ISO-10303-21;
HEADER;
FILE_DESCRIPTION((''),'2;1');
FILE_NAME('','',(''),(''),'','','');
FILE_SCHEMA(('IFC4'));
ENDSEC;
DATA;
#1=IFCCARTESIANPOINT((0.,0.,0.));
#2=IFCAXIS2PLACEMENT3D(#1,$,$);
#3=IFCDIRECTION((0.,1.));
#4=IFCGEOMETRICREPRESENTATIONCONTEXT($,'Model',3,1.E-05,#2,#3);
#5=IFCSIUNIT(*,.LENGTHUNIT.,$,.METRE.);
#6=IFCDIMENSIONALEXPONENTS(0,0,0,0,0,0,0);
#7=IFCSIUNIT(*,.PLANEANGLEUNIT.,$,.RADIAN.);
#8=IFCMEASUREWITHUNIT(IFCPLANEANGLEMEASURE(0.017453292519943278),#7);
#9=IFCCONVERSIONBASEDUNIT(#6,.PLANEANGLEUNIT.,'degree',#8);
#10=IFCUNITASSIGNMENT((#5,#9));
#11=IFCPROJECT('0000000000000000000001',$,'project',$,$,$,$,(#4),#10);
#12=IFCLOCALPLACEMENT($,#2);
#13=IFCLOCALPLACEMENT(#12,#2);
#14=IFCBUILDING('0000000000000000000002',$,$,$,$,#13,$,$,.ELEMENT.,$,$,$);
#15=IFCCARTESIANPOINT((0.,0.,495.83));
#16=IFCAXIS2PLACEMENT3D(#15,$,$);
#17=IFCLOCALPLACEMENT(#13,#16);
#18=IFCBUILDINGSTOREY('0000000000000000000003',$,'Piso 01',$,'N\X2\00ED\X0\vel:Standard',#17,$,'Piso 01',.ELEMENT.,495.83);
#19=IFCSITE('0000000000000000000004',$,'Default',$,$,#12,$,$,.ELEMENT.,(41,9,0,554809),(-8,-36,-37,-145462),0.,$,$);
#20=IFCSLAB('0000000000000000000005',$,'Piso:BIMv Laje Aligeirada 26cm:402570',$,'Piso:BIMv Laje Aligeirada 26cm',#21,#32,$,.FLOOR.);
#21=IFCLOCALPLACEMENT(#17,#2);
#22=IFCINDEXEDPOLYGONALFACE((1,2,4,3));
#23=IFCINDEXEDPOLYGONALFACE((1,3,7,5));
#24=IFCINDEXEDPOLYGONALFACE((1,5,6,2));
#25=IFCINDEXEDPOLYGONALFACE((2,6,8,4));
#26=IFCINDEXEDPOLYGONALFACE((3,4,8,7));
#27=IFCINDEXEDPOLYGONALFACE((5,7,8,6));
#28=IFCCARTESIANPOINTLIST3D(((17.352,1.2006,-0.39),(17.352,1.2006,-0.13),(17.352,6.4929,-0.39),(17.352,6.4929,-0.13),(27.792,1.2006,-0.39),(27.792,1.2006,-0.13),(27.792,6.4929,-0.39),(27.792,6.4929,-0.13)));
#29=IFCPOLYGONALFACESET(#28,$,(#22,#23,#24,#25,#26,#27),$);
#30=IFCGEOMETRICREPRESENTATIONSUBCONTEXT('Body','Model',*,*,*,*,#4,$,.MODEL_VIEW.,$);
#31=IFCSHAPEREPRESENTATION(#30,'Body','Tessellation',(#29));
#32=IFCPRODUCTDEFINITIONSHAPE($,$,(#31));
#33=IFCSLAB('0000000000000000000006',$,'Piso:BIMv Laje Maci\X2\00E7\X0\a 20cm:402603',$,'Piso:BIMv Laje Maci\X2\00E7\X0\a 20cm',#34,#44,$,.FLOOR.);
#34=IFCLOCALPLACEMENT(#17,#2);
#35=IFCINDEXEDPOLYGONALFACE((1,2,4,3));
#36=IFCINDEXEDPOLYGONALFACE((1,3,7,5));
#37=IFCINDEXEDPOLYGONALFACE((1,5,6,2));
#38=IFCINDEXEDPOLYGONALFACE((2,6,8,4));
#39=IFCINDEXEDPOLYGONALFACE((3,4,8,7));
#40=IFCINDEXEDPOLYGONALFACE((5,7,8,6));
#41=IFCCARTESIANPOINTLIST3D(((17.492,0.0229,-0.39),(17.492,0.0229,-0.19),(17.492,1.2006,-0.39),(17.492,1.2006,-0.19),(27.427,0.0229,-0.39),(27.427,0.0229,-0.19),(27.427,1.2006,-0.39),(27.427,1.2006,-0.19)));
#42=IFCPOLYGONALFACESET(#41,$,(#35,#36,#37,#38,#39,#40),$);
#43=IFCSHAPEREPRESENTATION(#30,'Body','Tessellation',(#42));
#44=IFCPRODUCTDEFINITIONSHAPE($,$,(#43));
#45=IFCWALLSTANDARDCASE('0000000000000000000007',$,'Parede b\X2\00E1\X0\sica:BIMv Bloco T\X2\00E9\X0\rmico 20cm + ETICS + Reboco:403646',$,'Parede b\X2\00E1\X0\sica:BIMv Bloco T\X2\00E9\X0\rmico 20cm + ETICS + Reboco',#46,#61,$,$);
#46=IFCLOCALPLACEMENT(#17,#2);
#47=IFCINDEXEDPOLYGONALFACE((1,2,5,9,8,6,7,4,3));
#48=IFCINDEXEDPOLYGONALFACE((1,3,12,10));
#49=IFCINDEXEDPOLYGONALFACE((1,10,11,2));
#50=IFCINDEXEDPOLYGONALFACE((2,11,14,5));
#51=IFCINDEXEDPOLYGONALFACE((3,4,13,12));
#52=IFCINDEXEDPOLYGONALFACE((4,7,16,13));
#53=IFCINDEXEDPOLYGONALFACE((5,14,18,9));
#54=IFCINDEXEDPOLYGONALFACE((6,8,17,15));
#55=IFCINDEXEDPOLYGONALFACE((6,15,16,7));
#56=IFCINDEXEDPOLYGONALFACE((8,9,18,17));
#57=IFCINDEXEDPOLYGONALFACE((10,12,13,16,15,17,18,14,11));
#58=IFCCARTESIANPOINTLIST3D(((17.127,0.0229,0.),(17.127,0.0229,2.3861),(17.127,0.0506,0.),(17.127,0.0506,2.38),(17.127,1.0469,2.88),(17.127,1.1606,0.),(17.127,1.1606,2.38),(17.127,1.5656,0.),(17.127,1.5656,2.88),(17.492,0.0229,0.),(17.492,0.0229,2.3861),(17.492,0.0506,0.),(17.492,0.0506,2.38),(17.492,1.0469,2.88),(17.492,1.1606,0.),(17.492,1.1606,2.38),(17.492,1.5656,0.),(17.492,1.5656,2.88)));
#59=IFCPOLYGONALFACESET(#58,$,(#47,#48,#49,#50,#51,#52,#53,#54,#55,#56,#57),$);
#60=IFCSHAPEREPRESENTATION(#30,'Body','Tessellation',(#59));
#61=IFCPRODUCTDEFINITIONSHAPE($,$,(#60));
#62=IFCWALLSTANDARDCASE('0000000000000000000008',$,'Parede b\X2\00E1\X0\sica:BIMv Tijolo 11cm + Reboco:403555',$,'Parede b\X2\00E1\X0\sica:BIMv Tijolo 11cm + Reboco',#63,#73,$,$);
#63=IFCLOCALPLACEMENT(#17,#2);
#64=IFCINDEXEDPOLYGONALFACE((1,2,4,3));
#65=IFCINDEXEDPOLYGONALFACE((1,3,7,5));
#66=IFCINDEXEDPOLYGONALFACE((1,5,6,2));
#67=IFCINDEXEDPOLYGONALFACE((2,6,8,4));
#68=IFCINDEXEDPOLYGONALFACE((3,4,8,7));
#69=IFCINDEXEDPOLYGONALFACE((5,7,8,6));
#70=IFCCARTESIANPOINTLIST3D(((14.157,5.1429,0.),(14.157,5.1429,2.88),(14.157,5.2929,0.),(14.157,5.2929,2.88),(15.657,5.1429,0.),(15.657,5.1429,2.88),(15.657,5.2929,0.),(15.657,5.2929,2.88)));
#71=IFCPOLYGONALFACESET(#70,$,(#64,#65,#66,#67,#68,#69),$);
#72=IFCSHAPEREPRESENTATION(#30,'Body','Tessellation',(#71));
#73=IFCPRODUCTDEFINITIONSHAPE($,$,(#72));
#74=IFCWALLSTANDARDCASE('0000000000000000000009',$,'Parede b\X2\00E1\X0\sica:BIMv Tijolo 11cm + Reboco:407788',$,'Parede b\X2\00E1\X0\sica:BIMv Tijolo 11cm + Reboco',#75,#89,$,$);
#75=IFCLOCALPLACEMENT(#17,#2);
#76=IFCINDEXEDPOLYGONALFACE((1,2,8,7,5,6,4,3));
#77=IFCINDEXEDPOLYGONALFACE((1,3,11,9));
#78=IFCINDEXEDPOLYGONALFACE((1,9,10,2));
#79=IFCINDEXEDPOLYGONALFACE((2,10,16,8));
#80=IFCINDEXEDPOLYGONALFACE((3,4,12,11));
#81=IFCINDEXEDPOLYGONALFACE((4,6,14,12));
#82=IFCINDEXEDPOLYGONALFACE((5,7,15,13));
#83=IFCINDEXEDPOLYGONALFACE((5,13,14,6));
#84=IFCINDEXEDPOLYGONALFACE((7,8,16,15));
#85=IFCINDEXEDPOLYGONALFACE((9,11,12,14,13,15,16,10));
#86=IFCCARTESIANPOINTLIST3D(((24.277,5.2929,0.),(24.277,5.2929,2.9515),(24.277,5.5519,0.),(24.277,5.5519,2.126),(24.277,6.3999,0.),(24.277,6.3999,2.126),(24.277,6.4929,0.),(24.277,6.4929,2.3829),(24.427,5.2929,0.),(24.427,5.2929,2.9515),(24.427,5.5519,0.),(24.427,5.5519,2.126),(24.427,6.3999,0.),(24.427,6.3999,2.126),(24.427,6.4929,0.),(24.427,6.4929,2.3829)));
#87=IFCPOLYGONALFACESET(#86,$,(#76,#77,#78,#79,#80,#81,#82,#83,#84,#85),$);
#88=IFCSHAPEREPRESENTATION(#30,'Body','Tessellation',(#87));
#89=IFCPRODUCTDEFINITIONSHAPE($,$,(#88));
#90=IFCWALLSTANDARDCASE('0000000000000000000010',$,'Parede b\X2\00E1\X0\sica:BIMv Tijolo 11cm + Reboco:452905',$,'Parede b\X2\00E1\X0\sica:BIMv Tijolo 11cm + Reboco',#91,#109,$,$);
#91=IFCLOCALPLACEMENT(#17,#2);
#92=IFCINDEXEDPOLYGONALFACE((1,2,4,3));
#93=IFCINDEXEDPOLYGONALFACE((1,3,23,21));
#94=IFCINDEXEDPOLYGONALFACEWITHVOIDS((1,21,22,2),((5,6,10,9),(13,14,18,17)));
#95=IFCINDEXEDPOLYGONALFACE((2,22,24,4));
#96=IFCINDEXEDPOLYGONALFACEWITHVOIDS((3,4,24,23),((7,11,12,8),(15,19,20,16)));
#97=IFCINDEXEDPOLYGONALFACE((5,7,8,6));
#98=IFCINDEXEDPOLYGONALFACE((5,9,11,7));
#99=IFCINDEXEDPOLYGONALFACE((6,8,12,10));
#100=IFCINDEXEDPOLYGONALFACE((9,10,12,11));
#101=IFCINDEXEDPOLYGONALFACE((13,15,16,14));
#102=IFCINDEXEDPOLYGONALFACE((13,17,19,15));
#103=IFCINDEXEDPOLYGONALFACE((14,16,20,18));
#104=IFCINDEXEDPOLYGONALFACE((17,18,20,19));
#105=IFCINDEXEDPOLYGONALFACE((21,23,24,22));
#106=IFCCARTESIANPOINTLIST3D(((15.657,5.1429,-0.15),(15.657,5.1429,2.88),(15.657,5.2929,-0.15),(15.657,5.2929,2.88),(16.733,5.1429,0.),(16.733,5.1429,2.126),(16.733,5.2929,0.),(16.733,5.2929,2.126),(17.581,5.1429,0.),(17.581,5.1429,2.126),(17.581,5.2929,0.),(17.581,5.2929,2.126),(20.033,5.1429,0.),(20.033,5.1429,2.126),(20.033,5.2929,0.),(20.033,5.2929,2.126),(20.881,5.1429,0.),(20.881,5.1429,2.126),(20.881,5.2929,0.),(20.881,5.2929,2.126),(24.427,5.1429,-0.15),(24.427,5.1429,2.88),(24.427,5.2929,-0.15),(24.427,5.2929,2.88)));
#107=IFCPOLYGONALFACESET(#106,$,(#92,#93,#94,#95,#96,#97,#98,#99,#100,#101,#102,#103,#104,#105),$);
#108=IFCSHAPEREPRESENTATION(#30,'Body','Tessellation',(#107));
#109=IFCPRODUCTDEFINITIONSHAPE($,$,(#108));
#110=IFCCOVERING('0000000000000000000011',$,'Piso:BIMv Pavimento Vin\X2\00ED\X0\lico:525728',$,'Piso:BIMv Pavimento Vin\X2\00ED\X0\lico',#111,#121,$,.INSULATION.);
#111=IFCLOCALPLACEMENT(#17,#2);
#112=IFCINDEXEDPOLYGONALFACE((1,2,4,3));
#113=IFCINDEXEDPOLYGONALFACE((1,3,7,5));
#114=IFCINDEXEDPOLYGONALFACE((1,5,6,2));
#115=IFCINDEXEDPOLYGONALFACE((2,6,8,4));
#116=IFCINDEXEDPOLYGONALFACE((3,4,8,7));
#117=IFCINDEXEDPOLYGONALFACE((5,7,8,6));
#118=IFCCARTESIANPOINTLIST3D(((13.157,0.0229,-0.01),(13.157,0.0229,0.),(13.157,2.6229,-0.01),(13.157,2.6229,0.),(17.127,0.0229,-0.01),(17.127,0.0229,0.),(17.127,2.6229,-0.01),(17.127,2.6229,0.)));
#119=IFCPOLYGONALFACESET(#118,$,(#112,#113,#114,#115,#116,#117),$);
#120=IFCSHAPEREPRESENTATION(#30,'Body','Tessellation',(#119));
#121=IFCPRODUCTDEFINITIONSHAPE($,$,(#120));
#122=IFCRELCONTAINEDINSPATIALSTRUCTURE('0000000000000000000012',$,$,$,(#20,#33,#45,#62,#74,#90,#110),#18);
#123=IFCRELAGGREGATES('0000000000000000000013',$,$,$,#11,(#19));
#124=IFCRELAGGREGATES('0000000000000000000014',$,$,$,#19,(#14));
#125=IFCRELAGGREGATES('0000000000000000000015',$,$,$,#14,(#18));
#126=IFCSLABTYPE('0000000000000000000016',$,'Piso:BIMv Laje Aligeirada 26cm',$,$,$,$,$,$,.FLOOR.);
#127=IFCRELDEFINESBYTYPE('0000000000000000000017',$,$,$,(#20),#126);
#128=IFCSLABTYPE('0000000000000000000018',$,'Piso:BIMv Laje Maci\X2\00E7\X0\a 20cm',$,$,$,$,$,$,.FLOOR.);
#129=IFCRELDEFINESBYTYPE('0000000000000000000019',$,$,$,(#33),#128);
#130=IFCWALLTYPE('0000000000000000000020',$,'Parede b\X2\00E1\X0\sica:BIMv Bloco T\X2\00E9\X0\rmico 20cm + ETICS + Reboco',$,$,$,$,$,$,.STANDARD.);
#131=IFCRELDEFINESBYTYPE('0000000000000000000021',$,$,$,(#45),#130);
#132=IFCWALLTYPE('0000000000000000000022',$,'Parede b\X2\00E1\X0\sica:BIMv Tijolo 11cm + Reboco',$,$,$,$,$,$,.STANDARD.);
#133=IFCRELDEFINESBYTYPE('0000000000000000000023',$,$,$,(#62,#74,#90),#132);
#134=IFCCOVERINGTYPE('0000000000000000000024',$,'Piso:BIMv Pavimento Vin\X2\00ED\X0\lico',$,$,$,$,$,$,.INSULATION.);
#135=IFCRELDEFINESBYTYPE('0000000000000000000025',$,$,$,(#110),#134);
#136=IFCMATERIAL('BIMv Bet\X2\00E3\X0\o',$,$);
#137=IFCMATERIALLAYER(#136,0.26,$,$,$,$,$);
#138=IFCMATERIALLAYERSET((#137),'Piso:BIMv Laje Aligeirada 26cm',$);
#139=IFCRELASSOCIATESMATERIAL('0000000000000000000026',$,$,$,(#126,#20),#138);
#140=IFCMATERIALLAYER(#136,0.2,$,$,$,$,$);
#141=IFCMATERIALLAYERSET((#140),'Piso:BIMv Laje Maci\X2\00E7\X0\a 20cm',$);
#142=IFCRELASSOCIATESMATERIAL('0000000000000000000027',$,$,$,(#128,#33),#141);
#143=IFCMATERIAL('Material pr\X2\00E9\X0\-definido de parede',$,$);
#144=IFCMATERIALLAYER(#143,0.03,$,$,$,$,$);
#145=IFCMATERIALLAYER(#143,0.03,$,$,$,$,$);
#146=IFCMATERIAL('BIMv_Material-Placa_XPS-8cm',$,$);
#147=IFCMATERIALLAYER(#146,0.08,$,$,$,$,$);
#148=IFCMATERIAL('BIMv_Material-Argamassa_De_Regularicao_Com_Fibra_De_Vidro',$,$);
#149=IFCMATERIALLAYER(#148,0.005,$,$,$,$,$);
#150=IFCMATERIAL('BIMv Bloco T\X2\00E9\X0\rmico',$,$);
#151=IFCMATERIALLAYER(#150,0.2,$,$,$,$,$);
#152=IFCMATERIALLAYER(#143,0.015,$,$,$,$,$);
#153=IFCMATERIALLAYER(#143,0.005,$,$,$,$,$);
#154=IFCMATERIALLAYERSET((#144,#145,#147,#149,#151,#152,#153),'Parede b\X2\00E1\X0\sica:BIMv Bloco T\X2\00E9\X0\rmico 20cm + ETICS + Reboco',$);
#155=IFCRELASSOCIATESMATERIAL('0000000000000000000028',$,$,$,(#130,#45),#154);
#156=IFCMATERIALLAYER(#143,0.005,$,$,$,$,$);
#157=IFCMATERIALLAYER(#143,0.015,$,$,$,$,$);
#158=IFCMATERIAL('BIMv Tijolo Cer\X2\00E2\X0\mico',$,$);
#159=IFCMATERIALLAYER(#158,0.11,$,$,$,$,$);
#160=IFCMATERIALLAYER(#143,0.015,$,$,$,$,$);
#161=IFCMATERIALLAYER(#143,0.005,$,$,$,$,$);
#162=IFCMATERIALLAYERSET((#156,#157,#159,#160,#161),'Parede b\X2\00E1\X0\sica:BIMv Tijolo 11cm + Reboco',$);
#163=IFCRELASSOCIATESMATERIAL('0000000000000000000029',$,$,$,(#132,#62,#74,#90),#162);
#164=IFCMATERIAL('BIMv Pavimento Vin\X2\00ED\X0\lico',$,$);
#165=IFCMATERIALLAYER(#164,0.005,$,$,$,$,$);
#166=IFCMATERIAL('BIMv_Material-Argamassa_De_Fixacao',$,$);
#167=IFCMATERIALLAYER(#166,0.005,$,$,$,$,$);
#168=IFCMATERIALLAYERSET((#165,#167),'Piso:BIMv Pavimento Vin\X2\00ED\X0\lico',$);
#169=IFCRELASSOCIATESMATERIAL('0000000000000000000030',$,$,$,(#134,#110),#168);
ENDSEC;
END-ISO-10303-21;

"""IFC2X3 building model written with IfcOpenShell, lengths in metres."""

from ifc_helpers import new_model, entity, si_unit, converted_unit, direction, frame, frame_2d, origin, origin_2d_with_axis, place, context, subcontext, project, spatial, polyline, rectangle, extrude, clip, halfspace, bounded_halfspace, material, layer, layer_set, layer_usage, type_object, element, save


model = new_model("IFC2X3")

# Units and contexts
model_context = context("Model", 3, precision=1e-05, world=origin(), true_north=direction((0.0, 1.0)))
body_context = subcontext(model_context, "Body", "Model", "MODEL_VIEW")
ifc_project = project(units=[si_unit("LENGTHUNIT", "METRE"), converted_unit("PLANEANGLEUNIT", "degree", entity("IfcPlaneAngleMeasure", 0.017453292519943278), si_unit("PLANEANGLEUNIT", "RADIAN"), dimensions=[0, 0, 0, 0, 0, 0, 0])], contexts=[model_context])

# Site, building, storey
site_placement = place(None, origin())
site = spatial("IfcSite", under=ifc_project, at=site_placement, Name="Default", CompositionType="ELEMENT", RefLatitude=(41, 9, 0, 554809), RefLongitude=(-8, -36, -37, -145462), RefElevation=0.0)
building_placement = place(site_placement, origin())
building = spatial("IfcBuilding", under=site, at=building_placement, CompositionType="ELEMENT")
storey_placement = place(building_placement, frame((0.0, 0.0, 495.83)))
storey = spatial("IfcBuildingStorey", under=building, at=storey_placement, Name="Piso 01", ObjectType="Nível:Standard", LongName="Piso 01", CompositionType="ELEMENT", Elevation=495.83)

# Slabs
ifc_material_1 = material(Name="BIMv Betão")
ifc_layer_1 = layer(ifc_material_1, 0.26)
ifc_layer_set_1 = layer_set([ifc_layer_1], Name="Piso:BIMv Laje Aligeirada 26cm")
slab_type_1 = type_object("IfcSlabType", Name="Piso:BIMv Laje Aligeirada 26cm", PredefinedType="FLOOR", material=ifc_layer_set_1)
ifc_layer_usage_1 = layer_usage(ifc_layer_set_1, "AXIS3", "POSITIVE", 0.0)
slab_1_placement = place(storey_placement, origin())
element("IfcSlab", 1, at=slab_1_placement, inside=storey, type_object=slab_type_1, material=ifc_layer_usage_1, Name="Piso:BIMv Laje Aligeirada 26cm:402570", ObjectType="Piso:BIMv Laje Aligeirada 26cm", PredefinedType="FLOOR", context=body_context, shape_type="SweptSolid", body=[
    extrude(rectangle(XDim=5.2923, YDim=10.44, at=frame_2d((0.0, 0.0), x_axis=(1.0, 0.0))), frame((22.572, 3.8468, -0.13), z_axis=(0.0, 0.0, -1.0), x_axis=(0.0, 1.0, 0.0)), (0.0, 0.0, 1.0), 0.26),
])
ifc_layer_2 = layer(ifc_material_1, 0.2)
ifc_layer_set_2 = layer_set([ifc_layer_2], Name="Piso:BIMv Laje Maciça 20cm")
ifc_layer_usage_2 = layer_usage(ifc_layer_set_2, "AXIS3", "POSITIVE", 0.0)
slab_type_2 = type_object("IfcSlabType", Name="Piso:BIMv Laje Maciça 20cm", PredefinedType="FLOOR", material=ifc_layer_set_2)
slab_2_placement = place(storey_placement, origin())
element("IfcSlab", 2, at=slab_2_placement, inside=storey, type_object=slab_type_2, material=ifc_layer_usage_2, Name="Piso:BIMv Laje Maciça 20cm:402603", ObjectType="Piso:BIMv Laje Maciça 20cm", PredefinedType="FLOOR", context=body_context, shape_type="SweptSolid", body=[
    extrude(rectangle(XDim=1.1777, YDim=9.935, at=frame_2d((0.0, 0.0), x_axis=(1.0, 0.0))), frame((22.4595, 0.6118, -0.19), z_axis=(0.0, 0.0, -1.0), x_axis=(0.0, 1.0, 0.0)), (0.0, 0.0, 1.0), 0.2),
])

# Wall, opening
ifc_material_2 = material(Name="Material pré-definido de parede")
ifc_layer_3 = layer(ifc_material_2, 0.03)
ifc_layer_4 = layer(ifc_material_2, 0.03)
ifc_material_3 = material(Name="BIMv_Material-Placa_XPS-8cm")
ifc_layer_5 = layer(ifc_material_3, 0.08)
ifc_material_4 = material(Name="BIMv_Material-Argamassa_De_Regularicao_Com_Fibra_De_Vidro")
ifc_layer_6 = layer(ifc_material_4, 0.005)
ifc_material_5 = material(Name="BIMv Bloco Térmico")
ifc_layer_7 = layer(ifc_material_5, 0.2)
ifc_layer_8 = layer(ifc_material_2, 0.015)
ifc_layer_9 = layer(ifc_material_2, 0.005)
ifc_layer_set_3 = layer_set([ifc_layer_3, ifc_layer_4, ifc_layer_5, ifc_layer_6, ifc_layer_7, ifc_layer_8, ifc_layer_9], Name="Parede básica:BIMv Bloco Térmico 20cm + ETICS + Reboco")
ifc_layer_usage_3 = layer_usage(ifc_layer_set_3, "AXIS2", "POSITIVE", -0.1825)
wall_type_1 = type_object("IfcWallType", Name="Parede básica:BIMv Bloco Térmico 20cm + ETICS + Reboco", PredefinedType="STANDARD", material=ifc_layer_set_3)
wall_1_placement = place(storey_placement, frame((17.3095, 0.0229, 0.0), z_axis=(0.0, 0.0, 1.0), x_axis=(0.0, 1.0, 0.0)))
wall_1 = element("IfcWallStandardCase", 3, at=wall_1_placement, inside=storey, type_object=wall_type_1, material=ifc_layer_usage_3, Name="Parede básica:BIMv Bloco Térmico 20cm + ETICS + Reboco:403646", ObjectType="Parede básica:BIMv Bloco Térmico 20cm + ETICS + Reboco", context=body_context, shape_type="Clipping", body=[
    clip(clip(extrude(rectangle(XDim=1.5427, YDim=0.365, at=frame_2d((0.7714, 0.0), x_axis=(1.0, 0.0))), origin(), (0.0, 0.0, 1.0), 2.88), bounded_halfspace(frame((0.0, -0.1825, 2.3861), z_axis=(-0.43445, 0.0, 0.900696), x_axis=(0.900696, 0.0, 0.43445)), False, frame((0.0, -0.1825, 2.3861)), polyline([(0.0, 0.0), (1.1777, 0.0), (1.5427, 0.0), (1.5427, 0.365), (0.0, 0.365), (0.0, 0.0)]))), halfspace(origin(), True)),
])
opening_1_placement = place(wall_1_placement, frame((0.0277, -0.1825, 0.0)))
element("IfcOpeningElement", 4, at=opening_1_placement, cuts=wall_1, ObjectType="Opening", context=body_context, shape_type="SweptSolid", body=[
    extrude(rectangle(XDim=2.38, YDim=1.11, at=frame_2d((1.19, 0.555), x_axis=(-1.0, 0.0))), frame((0.0, 0.0, 0.0), z_axis=(0.0, 1.0, 0.0), x_axis=(0.0, 0.0, 1.0)), (0.0, 0.0, 1.0), 0.365),
])

# Wall
ifc_layer_10 = layer(ifc_material_2, 0.005)
ifc_layer_11 = layer(ifc_material_2, 0.015)
ifc_material_6 = material(Name="BIMv Tijolo Cerâmico")
ifc_layer_12 = layer(ifc_material_6, 0.11)
ifc_layer_13 = layer(ifc_material_2, 0.015)
ifc_layer_14 = layer(ifc_material_2, 0.005)
ifc_layer_set_4 = layer_set([ifc_layer_10, ifc_layer_11, ifc_layer_12, ifc_layer_13, ifc_layer_14], Name="Parede básica:BIMv Tijolo 11cm + Reboco")
ifc_layer_usage_4 = layer_usage(ifc_layer_set_4, "AXIS2", "NEGATIVE", 0.075)
wall_type_2 = type_object("IfcWallType", Name="Parede básica:BIMv Tijolo 11cm + Reboco", PredefinedType="STANDARD", material=ifc_layer_set_4)
wall_2_placement = place(storey_placement, frame((14.157, 5.2179, 0.0)))
element("IfcWallStandardCase", 5, at=wall_2_placement, inside=storey, type_object=wall_type_2, material=ifc_layer_usage_4, Name="Parede básica:BIMv Tijolo 11cm + Reboco:403555", ObjectType="Parede básica:BIMv Tijolo 11cm + Reboco", context=body_context, shape_type="Clipping", body=[
    clip(extrude(rectangle(XDim=1.5, YDim=0.15, at=frame_2d((0.75, 0.0), x_axis=(1.0, 0.0))), origin(), (0.0, 0.0, 1.0), 2.88), halfspace(origin(), True)),
])

# Wall, opening
ifc_layer_usage_5 = layer_usage(ifc_layer_set_4, "AXIS2", "NEGATIVE", 0.075)
wall_3_placement = place(storey_placement, frame((24.352, 5.2929, 0.0), z_axis=(0.0, 0.0, 1.0), x_axis=(0.0, 1.0, 0.0)))
wall_3 = element("IfcWallStandardCase", 6, at=wall_3_placement, inside=storey, type_object=wall_type_2, material=ifc_layer_usage_5, Name="Parede básica:BIMv Tijolo 11cm + Reboco:407788", ObjectType="Parede básica:BIMv Tijolo 11cm + Reboco", context=body_context, shape_type="Clipping", body=[
    clip(extrude(rectangle(XDim=1.2, YDim=0.15, at=frame_2d((0.6, 0.0), x_axis=(1.0, 0.0))), origin(), (0.0, 0.0, 1.0), 2.9515), bounded_halfspace(frame((0.0, -0.075, 2.9515), z_axis=(0.42819, 0.0, 0.903689), x_axis=(0.0, 1.0, 0.0)), False, frame((0.0, -0.075, 2.9515)), polyline([(0.0, 0.0), (1.2, 0.0), (1.2, 0.15), (0.0, 0.15), (0.0, 0.0)]))),
])
opening_2_placement = place(wall_3_placement, frame((1.107, 0.075, 0.0)))
element("IfcOpeningElement", 7, at=opening_2_placement, cuts=wall_3, ObjectType="Opening", context=body_context, shape_type="SweptSolid", body=[
    extrude(rectangle(XDim=2.126, YDim=0.848, at=frame_2d((1.063, 0.424), x_axis=(1.0, 0.0))), frame((0.0, 0.0, 0.0), z_axis=(0.0, -1.0, 0.0), x_axis=(0.0, 0.0, 1.0)), (0.0, 0.0, 1.0), 0.15),
])

# Wall, openings
ifc_layer_usage_6 = layer_usage(ifc_layer_set_4, "AXIS2", "NEGATIVE", 0.075)
wall_4_placement = place(storey_placement, frame((15.657, 5.2179, -0.15)))
wall_4 = element("IfcWallStandardCase", 8, at=wall_4_placement, inside=storey, type_object=wall_type_2, material=ifc_layer_usage_6, Name="Parede básica:BIMv Tijolo 11cm + Reboco:452905", ObjectType="Parede básica:BIMv Tijolo 11cm + Reboco", context=body_context, shape_type="Clipping", body=[
    clip(extrude(rectangle(XDim=8.77, YDim=0.15, at=frame_2d((4.385, 0.0), x_axis=(1.0, 0.0))), origin(), (0.0, 0.0, 1.0), 3.03), halfspace(frame((0.0, 0.0, -0.15)), True)),
])
opening_3_placement = place(wall_4_placement, origin())
element("IfcOpeningElement", 9, at=opening_3_placement, cuts=wall_4, ObjectType="Opening", context=body_context, shape_type="SweptSolid", body=[
    extrude(rectangle(XDim=2.126, YDim=0.15, at=frame_2d((0.0, 0.0), x_axis=(0.0, 1.0))), frame((8.695, 0.334, 1.213), z_axis=(0.0, 1.0, 0.0), x_axis=(1.0, 0.0, 0.0)), (0.0, 0.0, 1.0), 0.848),
])
opening_4_placement = place(wall_4_placement, frame((1.924, 0.075, 0.15)))
element("IfcOpeningElement", 10, at=opening_4_placement, cuts=wall_4, ObjectType="Opening", context=body_context, shape_type="SweptSolid", body=[
    extrude(rectangle(XDim=2.126, YDim=0.848, at=frame_2d((1.063, 0.424), x_axis=(1.0, 0.0))), frame((0.0, 0.0, 0.0), z_axis=(0.0, -1.0, 0.0), x_axis=(0.0, 0.0, 1.0)), (0.0, 0.0, 1.0), 0.15),
])
opening_5_placement = place(wall_4_placement, frame((-15.657, -5.2179, 0.15)))
element("IfcOpeningElement", 11, at=opening_5_placement, cuts=wall_4, ObjectType="Opening", context=body_context, shape_type="SweptSolid", body=[
    extrude(rectangle(XDim=2.126, YDim=0.848, at=frame_2d((0.0, 0.0), x_axis=(1.0, 0.0))), frame((17.157, 3.6189, 1.063), z_axis=(0.0, 1.0, 0.0), x_axis=(0.0, 0.0, 1.0)), (0.0, 0.0, 1.0), 3.048),
])
opening_6_placement = place(wall_4_placement, frame((5.224, 0.075, 0.15)))
element("IfcOpeningElement", 12, at=opening_6_placement, cuts=wall_4, ObjectType="Opening", context=body_context, shape_type="SweptSolid", body=[
    extrude(rectangle(XDim=2.126, YDim=0.848, at=frame_2d((1.063, 0.424), x_axis=(1.0, 0.0))), frame((0.0, 0.0, 0.0), z_axis=(0.0, -1.0, 0.0), x_axis=(0.0, 0.0, 1.0)), (0.0, 0.0, 1.0), 0.15),
])
opening_7_placement = place(wall_4_placement, frame((-15.657, -5.2179, 0.15)))
element("IfcOpeningElement", 13, at=opening_7_placement, cuts=wall_4, ObjectType="Opening", context=body_context, shape_type="SweptSolid", body=[
    extrude(rectangle(XDim=2.126, YDim=0.848, at=frame_2d((0.0, 0.0), x_axis=(1.0, 0.0))), frame((20.457, 3.6189, 1.063), z_axis=(0.0, 1.0, 0.0), x_axis=(0.0, 0.0, 1.0)), (0.0, 0.0, 1.0), 3.048),
])

# Covering
ifc_material_7 = material(Name="BIMv Pavimento Vinílico")
ifc_layer_15 = layer(ifc_material_7, 0.005)
ifc_material_8 = material(Name="BIMv_Material-Argamassa_De_Fixacao")
ifc_layer_16 = layer(ifc_material_8, 0.005)
ifc_layer_set_5 = layer_set([ifc_layer_15, ifc_layer_16], Name="Piso:BIMv Pavimento Vinílico")
ifc_layer_usage_7 = layer_usage(ifc_layer_set_5, "AXIS3", "POSITIVE", 0.0)
covering_type_1 = type_object("IfcCoveringType", Name="Piso:BIMv Pavimento Vinílico", PredefinedType="INSULATION", material=ifc_layer_set_5)
covering_1_placement = place(storey_placement, origin())
element("IfcCovering", 14, at=covering_1_placement, inside=storey, type_object=covering_type_1, material=ifc_layer_usage_7, Name="Piso:BIMv Pavimento Vinílico:525728", ObjectType="Piso:BIMv Pavimento Vinílico", PredefinedType="INSULATION", context=body_context, shape_type="SweptSolid", body=[
    extrude(rectangle(XDim=2.6, YDim=3.97, at=origin_2d_with_axis()), frame((15.142, 1.3229, 0.0), z_axis=(0.0, 0.0, -1.0), x_axis=(0.0, 1.0, 0.0)), (0.0, 0.0, 1.0), 0.01),
])

save(model, "model.ifc")
